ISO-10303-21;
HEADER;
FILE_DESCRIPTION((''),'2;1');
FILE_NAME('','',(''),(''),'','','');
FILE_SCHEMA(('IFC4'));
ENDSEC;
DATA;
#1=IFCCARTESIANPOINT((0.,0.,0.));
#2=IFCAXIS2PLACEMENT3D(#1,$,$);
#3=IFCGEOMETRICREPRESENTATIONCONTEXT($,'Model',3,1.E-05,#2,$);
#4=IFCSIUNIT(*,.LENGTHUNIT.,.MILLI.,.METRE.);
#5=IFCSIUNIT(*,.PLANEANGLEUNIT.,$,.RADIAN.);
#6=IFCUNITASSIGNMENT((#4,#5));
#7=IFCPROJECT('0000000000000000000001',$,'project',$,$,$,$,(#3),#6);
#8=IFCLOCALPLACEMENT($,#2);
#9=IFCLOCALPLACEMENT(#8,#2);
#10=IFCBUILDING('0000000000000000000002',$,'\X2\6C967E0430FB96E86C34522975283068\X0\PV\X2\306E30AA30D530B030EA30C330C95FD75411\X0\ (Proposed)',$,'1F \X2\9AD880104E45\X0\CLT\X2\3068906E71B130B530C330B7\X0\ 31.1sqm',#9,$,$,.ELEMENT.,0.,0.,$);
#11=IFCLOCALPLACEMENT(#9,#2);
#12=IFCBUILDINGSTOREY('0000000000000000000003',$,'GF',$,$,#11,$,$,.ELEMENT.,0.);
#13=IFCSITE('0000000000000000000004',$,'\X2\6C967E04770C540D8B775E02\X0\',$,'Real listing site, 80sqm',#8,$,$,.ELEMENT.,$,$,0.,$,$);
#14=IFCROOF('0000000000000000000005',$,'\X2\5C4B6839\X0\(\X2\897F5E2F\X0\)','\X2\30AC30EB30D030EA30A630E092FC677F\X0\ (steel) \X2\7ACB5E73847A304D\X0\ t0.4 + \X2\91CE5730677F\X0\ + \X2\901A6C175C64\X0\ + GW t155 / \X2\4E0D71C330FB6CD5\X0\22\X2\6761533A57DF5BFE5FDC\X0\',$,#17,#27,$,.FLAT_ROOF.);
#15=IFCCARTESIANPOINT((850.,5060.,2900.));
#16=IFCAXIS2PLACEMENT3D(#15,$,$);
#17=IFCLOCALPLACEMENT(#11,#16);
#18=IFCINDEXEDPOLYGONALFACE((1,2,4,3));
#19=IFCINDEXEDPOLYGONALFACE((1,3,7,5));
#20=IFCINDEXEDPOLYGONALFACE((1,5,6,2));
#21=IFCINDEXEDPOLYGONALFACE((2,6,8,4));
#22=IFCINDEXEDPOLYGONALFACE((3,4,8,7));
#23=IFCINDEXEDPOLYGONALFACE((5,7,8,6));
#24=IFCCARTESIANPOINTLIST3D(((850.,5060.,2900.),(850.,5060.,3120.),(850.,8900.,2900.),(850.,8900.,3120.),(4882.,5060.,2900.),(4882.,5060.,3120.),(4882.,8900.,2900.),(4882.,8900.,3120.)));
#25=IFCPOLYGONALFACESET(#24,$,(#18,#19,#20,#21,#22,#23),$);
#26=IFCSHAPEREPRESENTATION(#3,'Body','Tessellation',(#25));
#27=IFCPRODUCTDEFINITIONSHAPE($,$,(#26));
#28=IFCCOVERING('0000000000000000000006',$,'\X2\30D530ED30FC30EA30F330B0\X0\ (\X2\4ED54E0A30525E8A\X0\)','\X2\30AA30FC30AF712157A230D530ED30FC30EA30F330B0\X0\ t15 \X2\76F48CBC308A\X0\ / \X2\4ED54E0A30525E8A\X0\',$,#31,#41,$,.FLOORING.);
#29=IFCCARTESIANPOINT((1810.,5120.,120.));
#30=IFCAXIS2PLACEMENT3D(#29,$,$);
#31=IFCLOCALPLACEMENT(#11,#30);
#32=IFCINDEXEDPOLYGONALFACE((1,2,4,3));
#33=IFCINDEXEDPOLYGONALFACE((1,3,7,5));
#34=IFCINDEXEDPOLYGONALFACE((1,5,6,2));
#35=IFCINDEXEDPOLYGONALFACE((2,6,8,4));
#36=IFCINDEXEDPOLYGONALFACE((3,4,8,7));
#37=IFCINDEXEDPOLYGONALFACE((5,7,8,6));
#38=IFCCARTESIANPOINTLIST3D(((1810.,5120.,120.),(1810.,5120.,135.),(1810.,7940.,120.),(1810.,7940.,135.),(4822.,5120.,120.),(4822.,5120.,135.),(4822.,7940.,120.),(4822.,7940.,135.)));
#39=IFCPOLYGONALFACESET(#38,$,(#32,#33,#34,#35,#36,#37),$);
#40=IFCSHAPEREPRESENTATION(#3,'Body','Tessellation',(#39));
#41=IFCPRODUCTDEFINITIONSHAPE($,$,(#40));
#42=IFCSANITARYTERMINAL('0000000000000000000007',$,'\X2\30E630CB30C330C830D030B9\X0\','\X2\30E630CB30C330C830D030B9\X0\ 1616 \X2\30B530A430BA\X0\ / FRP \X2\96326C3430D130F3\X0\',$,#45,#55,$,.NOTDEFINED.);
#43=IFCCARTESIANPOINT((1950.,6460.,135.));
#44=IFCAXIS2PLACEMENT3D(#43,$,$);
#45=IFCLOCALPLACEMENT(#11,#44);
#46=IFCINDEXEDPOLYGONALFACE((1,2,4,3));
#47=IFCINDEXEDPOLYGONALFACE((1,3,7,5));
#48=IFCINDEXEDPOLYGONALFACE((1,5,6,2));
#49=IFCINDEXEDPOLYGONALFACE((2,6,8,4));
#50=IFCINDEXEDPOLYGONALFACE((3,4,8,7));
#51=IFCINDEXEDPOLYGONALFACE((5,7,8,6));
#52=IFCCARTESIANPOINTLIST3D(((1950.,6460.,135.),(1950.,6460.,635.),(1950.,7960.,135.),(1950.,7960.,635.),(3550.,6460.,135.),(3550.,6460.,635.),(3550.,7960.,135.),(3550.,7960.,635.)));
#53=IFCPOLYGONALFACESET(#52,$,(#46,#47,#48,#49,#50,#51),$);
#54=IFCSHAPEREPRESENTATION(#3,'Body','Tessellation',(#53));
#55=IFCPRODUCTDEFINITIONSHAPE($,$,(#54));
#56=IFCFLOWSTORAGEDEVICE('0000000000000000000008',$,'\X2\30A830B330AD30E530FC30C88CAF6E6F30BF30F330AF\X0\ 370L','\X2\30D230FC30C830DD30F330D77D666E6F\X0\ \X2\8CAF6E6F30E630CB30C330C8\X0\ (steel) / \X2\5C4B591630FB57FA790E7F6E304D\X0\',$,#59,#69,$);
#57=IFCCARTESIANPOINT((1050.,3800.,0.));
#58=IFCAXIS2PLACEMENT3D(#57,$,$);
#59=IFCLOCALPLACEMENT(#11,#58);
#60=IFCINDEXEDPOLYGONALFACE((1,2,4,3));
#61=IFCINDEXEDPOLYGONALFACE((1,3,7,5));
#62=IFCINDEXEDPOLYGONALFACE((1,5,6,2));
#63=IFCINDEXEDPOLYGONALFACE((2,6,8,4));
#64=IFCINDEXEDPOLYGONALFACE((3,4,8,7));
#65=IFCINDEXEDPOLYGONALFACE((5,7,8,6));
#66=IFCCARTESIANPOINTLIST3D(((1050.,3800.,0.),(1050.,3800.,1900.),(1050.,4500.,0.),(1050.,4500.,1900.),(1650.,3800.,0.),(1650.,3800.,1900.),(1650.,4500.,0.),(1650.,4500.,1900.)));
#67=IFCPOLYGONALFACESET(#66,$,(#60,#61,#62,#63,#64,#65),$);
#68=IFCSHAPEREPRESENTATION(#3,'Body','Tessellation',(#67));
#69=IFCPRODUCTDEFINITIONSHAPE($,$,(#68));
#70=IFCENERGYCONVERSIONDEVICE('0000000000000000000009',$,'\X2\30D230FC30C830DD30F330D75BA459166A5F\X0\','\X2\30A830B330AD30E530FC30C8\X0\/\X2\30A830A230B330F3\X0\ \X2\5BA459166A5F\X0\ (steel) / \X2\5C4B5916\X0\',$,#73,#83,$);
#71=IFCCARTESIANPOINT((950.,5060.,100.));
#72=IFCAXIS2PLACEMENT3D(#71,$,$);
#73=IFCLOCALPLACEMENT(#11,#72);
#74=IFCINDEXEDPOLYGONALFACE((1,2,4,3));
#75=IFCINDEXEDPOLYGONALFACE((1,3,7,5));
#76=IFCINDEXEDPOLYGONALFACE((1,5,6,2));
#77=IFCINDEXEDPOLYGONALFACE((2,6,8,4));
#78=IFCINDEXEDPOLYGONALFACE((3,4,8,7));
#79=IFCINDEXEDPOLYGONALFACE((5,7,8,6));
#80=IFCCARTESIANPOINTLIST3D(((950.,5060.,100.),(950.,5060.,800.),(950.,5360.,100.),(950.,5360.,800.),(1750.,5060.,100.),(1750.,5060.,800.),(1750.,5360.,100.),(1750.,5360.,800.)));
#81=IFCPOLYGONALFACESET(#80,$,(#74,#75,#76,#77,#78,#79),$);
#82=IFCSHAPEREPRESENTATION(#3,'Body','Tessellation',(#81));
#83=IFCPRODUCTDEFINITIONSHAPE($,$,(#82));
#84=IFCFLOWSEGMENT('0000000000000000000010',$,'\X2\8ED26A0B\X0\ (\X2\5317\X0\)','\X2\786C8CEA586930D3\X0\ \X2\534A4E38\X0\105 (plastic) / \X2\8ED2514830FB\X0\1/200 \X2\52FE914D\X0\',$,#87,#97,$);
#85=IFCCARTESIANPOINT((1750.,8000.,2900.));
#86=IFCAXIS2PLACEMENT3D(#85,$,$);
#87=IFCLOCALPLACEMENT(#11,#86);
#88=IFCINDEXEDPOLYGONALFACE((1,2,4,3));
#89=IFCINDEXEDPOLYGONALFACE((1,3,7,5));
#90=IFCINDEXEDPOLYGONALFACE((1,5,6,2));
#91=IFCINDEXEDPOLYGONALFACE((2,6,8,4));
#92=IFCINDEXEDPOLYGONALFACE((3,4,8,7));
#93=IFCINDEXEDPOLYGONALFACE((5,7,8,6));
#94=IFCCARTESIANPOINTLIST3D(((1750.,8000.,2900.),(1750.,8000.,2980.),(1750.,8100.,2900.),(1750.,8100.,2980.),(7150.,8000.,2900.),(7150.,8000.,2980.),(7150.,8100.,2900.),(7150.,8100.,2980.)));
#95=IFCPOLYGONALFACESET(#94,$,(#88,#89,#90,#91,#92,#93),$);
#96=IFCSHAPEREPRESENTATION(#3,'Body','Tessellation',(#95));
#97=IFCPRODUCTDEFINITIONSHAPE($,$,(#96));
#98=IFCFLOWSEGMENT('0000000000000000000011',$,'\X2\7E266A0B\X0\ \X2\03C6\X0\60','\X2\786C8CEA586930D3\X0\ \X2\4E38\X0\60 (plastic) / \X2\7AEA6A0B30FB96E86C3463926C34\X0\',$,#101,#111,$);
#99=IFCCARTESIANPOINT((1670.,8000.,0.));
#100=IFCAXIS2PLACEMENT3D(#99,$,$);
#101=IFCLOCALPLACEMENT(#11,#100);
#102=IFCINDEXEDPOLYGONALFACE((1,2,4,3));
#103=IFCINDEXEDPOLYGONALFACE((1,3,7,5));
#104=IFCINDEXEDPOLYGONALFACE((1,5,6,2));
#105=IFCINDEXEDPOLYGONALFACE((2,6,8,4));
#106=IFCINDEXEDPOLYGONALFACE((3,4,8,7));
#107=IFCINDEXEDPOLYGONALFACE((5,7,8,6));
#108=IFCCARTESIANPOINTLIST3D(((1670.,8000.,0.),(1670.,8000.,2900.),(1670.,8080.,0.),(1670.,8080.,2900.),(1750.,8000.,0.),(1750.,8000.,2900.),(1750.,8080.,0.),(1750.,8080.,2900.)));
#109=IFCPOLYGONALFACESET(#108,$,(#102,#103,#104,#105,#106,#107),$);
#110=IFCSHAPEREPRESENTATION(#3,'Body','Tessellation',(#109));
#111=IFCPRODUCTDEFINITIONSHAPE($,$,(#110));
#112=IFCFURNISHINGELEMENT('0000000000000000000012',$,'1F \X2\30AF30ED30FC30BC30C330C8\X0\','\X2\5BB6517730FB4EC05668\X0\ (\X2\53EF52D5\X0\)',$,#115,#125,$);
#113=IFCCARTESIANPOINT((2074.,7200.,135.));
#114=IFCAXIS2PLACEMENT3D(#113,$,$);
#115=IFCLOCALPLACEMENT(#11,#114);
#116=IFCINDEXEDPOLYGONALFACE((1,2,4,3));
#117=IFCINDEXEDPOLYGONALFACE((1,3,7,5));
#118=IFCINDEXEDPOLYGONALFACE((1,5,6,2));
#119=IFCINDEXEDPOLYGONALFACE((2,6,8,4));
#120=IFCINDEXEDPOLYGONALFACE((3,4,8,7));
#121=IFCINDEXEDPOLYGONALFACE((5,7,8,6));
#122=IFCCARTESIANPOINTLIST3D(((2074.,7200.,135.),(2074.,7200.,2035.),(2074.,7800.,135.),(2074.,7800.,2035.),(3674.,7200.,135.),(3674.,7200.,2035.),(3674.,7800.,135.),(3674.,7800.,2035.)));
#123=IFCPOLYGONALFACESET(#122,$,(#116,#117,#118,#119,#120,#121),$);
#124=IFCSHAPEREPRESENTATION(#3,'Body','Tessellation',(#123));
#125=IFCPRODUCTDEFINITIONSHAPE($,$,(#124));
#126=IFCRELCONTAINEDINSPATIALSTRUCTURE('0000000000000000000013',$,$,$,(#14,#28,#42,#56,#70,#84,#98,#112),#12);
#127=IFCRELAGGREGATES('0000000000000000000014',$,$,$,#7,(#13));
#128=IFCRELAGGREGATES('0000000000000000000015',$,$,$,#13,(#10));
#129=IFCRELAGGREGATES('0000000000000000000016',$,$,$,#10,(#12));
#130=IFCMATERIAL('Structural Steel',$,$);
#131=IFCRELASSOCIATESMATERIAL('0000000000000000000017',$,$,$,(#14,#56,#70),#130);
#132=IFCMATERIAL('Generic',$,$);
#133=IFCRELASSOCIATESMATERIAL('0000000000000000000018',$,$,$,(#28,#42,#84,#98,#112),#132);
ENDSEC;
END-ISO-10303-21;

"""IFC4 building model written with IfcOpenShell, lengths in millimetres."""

from ifc_helpers import new_model, si_unit, frame, frame_2d, origin, place, context, project, spatial, rectangle, extrude, material, element, save


model = new_model("IFC4")

# Units and contexts
model_context = context("Model", 3, precision=1e-05, world=origin())
ifc_project = project(units=[si_unit("LENGTHUNIT", "METRE", prefix="MILLI"), si_unit("PLANEANGLEUNIT", "RADIAN")], contexts=[model_context])

# Site, building, storey
site_placement = place(None, origin())
site = spatial("IfcSite", under=ifc_project, at=site_placement, Name="沖縄県名護市", ObjectType="Real listing site, 80sqm", CompositionType="ELEMENT", RefElevation=0.0)
building_placement = place(site_placement, origin())
building = spatial("IfcBuilding", under=site, at=building_placement, Name="沖縄・雨水利用とPVのオフグリッド志向 (Proposed)", ObjectType="1F 高耐久CLTと遮熱サッシ 31.1sqm", CompositionType="ELEMENT", ElevationOfRefHeight=0.0, ElevationOfTerrain=0.0)
storey_placement = place(building_placement, origin())
storey = spatial("IfcBuildingStorey", under=building, at=storey_placement, Name="GF", CompositionType="ELEMENT", Elevation=0.0)

# Roof
ifc_material_1 = material(Name="Structural Steel")
roof_placement = place(storey_placement, frame((850.0, 5060.0, 2900.0)))
element("IfcRoof", 1, at=roof_placement, inside=storey, material=ifc_material_1, Name="屋根(西帯)", Description="ガルバリウム鋼板 (steel) 立平葺き t0.4 + 野地板 + 通気層 + GW t155 / 不燃・法22条区域対応", PredefinedType="FLAT_ROOF", context=model_context, shape_type="SweptSolid", body=[
    extrude(rectangle(XDim=4032.0, YDim=3840.0, at=frame_2d((2016.0, 1920.0))), frame((850.0, 5060.0, 2900.0)), (0.0, 0.0, 1.0), 220.0),
])

# Covering
ifc_material_2 = material(Name="Generic")
covering_placement = place(storey_placement, frame((1810.0, 5120.0, 120.0)))
element("IfcCovering", 2, at=covering_placement, inside=storey, material=ifc_material_2, Name="フローリング (仕上げ床)", Description="オーク無垢フローリング t15 直貼り / 仕上げ床", PredefinedType="FLOORING", context=model_context, shape_type="SweptSolid", body=[
    extrude(rectangle(XDim=3012.0, YDim=2820.0, at=frame_2d((1506.0, 1410.0))), frame((1810.0, 5120.0, 120.0)), (0.0, 0.0, 1.0), 15.0),
])

# Sanitary terminal
sanitary_terminal_placement = place(storey_placement, frame((1950.0, 6460.0, 135.0)))
element("IfcSanitaryTerminal", 3, at=sanitary_terminal_placement, inside=storey, material=ifc_material_2, Name="ユニットバス", Description="ユニットバス 1616 サイズ / FRP 防水パン", PredefinedType="NOTDEFINED", context=model_context, shape_type="SweptSolid", body=[
    extrude(rectangle(XDim=1600.0, YDim=1500.0, at=frame_2d((800.0, 750.0))), frame((1950.0, 6460.0, 135.0)), (0.0, 0.0, 1.0), 500.0),
])

# Flow storage device
flow_storage_device_placement = place(storey_placement, frame((1050.0, 3800.0, 0.0)))
element("IfcFlowStorageDevice", 4, at=flow_storage_device_placement, inside=storey, material=ifc_material_1, Name="エコキュート貯湯タンク 370L", Description="ヒートポンプ給湯 貯湯ユニット (steel) / 屋外・基礎置き", context=model_context, shape_type="SweptSolid", body=[
    extrude(rectangle(XDim=600.0, YDim=700.0, at=frame_2d((300.0, 350.0))), frame((1050.0, 3800.0, 0.0)), (0.0, 0.0, 1.0), 1900.0),
])

# Energy conversion device
energy_conversion_device_placement = place(storey_placement, frame((950.0, 5060.0, 100.0)))
element("IfcEnergyConversionDevice", 5, at=energy_conversion_device_placement, inside=storey, material=ifc_material_1, Name="ヒートポンプ室外機", Description="エコキュート/エアコン 室外機 (steel) / 屋外", context=model_context, shape_type="SweptSolid", body=[
    extrude(rectangle(XDim=800.0, YDim=300.0, at=frame_2d((400.0, 150.0))), frame((950.0, 5060.0, 100.0)), (0.0, 0.0, 1.0), 700.0),
])

# Flow segments
flow_segment_1_placement = place(storey_placement, frame((1750.0, 8000.0, 2900.0)))
element("IfcFlowSegment", 6, at=flow_segment_1_placement, inside=storey, material=ifc_material_2, Name="軒樋 (北)", Description="硬質塩ビ 半丸105 (plastic) / 軒先・1/200 勾配", context=model_context, shape_type="SweptSolid", body=[
    extrude(rectangle(XDim=5400.0, YDim=100.0, at=frame_2d((2700.0, 50.0))), frame((1750.0, 8000.0, 2900.0)), (0.0, 0.0, 1.0), 80.0),
])
flow_segment_2_placement = place(storey_placement, frame((1670.0, 8000.0, 0.0)))
element("IfcFlowSegment", 7, at=flow_segment_2_placement, inside=storey, material=ifc_material_2, Name="縦樋 φ60", Description="硬質塩ビ 丸60 (plastic) / 竪樋・雨水排水", context=model_context, shape_type="SweptSolid", body=[
    extrude(rectangle(XDim=80.0, YDim=80.0, at=frame_2d((40.0, 40.0))), frame((1670.0, 8000.0, 0.0)), (0.0, 0.0, 1.0), 2900.0),
])

# Furnishing element
furnishing_placement = place(storey_placement, frame((2074.0, 7200.0, 135.0)))
element("IfcFurnishingElement", 8, at=furnishing_placement, inside=storey, material=ifc_material_2, Name="1F クローゼット", Description="家具・什器 (可動)", context=model_context, shape_type="SweptSolid", body=[
    extrude(rectangle(XDim=1600.0, YDim=600.0, at=frame_2d((800.0, 300.0))), frame((2074.0, 7200.0, 135.0)), (0.0, 0.0, 1.0), 1900.0),
])

save(model, "model.ifc")
